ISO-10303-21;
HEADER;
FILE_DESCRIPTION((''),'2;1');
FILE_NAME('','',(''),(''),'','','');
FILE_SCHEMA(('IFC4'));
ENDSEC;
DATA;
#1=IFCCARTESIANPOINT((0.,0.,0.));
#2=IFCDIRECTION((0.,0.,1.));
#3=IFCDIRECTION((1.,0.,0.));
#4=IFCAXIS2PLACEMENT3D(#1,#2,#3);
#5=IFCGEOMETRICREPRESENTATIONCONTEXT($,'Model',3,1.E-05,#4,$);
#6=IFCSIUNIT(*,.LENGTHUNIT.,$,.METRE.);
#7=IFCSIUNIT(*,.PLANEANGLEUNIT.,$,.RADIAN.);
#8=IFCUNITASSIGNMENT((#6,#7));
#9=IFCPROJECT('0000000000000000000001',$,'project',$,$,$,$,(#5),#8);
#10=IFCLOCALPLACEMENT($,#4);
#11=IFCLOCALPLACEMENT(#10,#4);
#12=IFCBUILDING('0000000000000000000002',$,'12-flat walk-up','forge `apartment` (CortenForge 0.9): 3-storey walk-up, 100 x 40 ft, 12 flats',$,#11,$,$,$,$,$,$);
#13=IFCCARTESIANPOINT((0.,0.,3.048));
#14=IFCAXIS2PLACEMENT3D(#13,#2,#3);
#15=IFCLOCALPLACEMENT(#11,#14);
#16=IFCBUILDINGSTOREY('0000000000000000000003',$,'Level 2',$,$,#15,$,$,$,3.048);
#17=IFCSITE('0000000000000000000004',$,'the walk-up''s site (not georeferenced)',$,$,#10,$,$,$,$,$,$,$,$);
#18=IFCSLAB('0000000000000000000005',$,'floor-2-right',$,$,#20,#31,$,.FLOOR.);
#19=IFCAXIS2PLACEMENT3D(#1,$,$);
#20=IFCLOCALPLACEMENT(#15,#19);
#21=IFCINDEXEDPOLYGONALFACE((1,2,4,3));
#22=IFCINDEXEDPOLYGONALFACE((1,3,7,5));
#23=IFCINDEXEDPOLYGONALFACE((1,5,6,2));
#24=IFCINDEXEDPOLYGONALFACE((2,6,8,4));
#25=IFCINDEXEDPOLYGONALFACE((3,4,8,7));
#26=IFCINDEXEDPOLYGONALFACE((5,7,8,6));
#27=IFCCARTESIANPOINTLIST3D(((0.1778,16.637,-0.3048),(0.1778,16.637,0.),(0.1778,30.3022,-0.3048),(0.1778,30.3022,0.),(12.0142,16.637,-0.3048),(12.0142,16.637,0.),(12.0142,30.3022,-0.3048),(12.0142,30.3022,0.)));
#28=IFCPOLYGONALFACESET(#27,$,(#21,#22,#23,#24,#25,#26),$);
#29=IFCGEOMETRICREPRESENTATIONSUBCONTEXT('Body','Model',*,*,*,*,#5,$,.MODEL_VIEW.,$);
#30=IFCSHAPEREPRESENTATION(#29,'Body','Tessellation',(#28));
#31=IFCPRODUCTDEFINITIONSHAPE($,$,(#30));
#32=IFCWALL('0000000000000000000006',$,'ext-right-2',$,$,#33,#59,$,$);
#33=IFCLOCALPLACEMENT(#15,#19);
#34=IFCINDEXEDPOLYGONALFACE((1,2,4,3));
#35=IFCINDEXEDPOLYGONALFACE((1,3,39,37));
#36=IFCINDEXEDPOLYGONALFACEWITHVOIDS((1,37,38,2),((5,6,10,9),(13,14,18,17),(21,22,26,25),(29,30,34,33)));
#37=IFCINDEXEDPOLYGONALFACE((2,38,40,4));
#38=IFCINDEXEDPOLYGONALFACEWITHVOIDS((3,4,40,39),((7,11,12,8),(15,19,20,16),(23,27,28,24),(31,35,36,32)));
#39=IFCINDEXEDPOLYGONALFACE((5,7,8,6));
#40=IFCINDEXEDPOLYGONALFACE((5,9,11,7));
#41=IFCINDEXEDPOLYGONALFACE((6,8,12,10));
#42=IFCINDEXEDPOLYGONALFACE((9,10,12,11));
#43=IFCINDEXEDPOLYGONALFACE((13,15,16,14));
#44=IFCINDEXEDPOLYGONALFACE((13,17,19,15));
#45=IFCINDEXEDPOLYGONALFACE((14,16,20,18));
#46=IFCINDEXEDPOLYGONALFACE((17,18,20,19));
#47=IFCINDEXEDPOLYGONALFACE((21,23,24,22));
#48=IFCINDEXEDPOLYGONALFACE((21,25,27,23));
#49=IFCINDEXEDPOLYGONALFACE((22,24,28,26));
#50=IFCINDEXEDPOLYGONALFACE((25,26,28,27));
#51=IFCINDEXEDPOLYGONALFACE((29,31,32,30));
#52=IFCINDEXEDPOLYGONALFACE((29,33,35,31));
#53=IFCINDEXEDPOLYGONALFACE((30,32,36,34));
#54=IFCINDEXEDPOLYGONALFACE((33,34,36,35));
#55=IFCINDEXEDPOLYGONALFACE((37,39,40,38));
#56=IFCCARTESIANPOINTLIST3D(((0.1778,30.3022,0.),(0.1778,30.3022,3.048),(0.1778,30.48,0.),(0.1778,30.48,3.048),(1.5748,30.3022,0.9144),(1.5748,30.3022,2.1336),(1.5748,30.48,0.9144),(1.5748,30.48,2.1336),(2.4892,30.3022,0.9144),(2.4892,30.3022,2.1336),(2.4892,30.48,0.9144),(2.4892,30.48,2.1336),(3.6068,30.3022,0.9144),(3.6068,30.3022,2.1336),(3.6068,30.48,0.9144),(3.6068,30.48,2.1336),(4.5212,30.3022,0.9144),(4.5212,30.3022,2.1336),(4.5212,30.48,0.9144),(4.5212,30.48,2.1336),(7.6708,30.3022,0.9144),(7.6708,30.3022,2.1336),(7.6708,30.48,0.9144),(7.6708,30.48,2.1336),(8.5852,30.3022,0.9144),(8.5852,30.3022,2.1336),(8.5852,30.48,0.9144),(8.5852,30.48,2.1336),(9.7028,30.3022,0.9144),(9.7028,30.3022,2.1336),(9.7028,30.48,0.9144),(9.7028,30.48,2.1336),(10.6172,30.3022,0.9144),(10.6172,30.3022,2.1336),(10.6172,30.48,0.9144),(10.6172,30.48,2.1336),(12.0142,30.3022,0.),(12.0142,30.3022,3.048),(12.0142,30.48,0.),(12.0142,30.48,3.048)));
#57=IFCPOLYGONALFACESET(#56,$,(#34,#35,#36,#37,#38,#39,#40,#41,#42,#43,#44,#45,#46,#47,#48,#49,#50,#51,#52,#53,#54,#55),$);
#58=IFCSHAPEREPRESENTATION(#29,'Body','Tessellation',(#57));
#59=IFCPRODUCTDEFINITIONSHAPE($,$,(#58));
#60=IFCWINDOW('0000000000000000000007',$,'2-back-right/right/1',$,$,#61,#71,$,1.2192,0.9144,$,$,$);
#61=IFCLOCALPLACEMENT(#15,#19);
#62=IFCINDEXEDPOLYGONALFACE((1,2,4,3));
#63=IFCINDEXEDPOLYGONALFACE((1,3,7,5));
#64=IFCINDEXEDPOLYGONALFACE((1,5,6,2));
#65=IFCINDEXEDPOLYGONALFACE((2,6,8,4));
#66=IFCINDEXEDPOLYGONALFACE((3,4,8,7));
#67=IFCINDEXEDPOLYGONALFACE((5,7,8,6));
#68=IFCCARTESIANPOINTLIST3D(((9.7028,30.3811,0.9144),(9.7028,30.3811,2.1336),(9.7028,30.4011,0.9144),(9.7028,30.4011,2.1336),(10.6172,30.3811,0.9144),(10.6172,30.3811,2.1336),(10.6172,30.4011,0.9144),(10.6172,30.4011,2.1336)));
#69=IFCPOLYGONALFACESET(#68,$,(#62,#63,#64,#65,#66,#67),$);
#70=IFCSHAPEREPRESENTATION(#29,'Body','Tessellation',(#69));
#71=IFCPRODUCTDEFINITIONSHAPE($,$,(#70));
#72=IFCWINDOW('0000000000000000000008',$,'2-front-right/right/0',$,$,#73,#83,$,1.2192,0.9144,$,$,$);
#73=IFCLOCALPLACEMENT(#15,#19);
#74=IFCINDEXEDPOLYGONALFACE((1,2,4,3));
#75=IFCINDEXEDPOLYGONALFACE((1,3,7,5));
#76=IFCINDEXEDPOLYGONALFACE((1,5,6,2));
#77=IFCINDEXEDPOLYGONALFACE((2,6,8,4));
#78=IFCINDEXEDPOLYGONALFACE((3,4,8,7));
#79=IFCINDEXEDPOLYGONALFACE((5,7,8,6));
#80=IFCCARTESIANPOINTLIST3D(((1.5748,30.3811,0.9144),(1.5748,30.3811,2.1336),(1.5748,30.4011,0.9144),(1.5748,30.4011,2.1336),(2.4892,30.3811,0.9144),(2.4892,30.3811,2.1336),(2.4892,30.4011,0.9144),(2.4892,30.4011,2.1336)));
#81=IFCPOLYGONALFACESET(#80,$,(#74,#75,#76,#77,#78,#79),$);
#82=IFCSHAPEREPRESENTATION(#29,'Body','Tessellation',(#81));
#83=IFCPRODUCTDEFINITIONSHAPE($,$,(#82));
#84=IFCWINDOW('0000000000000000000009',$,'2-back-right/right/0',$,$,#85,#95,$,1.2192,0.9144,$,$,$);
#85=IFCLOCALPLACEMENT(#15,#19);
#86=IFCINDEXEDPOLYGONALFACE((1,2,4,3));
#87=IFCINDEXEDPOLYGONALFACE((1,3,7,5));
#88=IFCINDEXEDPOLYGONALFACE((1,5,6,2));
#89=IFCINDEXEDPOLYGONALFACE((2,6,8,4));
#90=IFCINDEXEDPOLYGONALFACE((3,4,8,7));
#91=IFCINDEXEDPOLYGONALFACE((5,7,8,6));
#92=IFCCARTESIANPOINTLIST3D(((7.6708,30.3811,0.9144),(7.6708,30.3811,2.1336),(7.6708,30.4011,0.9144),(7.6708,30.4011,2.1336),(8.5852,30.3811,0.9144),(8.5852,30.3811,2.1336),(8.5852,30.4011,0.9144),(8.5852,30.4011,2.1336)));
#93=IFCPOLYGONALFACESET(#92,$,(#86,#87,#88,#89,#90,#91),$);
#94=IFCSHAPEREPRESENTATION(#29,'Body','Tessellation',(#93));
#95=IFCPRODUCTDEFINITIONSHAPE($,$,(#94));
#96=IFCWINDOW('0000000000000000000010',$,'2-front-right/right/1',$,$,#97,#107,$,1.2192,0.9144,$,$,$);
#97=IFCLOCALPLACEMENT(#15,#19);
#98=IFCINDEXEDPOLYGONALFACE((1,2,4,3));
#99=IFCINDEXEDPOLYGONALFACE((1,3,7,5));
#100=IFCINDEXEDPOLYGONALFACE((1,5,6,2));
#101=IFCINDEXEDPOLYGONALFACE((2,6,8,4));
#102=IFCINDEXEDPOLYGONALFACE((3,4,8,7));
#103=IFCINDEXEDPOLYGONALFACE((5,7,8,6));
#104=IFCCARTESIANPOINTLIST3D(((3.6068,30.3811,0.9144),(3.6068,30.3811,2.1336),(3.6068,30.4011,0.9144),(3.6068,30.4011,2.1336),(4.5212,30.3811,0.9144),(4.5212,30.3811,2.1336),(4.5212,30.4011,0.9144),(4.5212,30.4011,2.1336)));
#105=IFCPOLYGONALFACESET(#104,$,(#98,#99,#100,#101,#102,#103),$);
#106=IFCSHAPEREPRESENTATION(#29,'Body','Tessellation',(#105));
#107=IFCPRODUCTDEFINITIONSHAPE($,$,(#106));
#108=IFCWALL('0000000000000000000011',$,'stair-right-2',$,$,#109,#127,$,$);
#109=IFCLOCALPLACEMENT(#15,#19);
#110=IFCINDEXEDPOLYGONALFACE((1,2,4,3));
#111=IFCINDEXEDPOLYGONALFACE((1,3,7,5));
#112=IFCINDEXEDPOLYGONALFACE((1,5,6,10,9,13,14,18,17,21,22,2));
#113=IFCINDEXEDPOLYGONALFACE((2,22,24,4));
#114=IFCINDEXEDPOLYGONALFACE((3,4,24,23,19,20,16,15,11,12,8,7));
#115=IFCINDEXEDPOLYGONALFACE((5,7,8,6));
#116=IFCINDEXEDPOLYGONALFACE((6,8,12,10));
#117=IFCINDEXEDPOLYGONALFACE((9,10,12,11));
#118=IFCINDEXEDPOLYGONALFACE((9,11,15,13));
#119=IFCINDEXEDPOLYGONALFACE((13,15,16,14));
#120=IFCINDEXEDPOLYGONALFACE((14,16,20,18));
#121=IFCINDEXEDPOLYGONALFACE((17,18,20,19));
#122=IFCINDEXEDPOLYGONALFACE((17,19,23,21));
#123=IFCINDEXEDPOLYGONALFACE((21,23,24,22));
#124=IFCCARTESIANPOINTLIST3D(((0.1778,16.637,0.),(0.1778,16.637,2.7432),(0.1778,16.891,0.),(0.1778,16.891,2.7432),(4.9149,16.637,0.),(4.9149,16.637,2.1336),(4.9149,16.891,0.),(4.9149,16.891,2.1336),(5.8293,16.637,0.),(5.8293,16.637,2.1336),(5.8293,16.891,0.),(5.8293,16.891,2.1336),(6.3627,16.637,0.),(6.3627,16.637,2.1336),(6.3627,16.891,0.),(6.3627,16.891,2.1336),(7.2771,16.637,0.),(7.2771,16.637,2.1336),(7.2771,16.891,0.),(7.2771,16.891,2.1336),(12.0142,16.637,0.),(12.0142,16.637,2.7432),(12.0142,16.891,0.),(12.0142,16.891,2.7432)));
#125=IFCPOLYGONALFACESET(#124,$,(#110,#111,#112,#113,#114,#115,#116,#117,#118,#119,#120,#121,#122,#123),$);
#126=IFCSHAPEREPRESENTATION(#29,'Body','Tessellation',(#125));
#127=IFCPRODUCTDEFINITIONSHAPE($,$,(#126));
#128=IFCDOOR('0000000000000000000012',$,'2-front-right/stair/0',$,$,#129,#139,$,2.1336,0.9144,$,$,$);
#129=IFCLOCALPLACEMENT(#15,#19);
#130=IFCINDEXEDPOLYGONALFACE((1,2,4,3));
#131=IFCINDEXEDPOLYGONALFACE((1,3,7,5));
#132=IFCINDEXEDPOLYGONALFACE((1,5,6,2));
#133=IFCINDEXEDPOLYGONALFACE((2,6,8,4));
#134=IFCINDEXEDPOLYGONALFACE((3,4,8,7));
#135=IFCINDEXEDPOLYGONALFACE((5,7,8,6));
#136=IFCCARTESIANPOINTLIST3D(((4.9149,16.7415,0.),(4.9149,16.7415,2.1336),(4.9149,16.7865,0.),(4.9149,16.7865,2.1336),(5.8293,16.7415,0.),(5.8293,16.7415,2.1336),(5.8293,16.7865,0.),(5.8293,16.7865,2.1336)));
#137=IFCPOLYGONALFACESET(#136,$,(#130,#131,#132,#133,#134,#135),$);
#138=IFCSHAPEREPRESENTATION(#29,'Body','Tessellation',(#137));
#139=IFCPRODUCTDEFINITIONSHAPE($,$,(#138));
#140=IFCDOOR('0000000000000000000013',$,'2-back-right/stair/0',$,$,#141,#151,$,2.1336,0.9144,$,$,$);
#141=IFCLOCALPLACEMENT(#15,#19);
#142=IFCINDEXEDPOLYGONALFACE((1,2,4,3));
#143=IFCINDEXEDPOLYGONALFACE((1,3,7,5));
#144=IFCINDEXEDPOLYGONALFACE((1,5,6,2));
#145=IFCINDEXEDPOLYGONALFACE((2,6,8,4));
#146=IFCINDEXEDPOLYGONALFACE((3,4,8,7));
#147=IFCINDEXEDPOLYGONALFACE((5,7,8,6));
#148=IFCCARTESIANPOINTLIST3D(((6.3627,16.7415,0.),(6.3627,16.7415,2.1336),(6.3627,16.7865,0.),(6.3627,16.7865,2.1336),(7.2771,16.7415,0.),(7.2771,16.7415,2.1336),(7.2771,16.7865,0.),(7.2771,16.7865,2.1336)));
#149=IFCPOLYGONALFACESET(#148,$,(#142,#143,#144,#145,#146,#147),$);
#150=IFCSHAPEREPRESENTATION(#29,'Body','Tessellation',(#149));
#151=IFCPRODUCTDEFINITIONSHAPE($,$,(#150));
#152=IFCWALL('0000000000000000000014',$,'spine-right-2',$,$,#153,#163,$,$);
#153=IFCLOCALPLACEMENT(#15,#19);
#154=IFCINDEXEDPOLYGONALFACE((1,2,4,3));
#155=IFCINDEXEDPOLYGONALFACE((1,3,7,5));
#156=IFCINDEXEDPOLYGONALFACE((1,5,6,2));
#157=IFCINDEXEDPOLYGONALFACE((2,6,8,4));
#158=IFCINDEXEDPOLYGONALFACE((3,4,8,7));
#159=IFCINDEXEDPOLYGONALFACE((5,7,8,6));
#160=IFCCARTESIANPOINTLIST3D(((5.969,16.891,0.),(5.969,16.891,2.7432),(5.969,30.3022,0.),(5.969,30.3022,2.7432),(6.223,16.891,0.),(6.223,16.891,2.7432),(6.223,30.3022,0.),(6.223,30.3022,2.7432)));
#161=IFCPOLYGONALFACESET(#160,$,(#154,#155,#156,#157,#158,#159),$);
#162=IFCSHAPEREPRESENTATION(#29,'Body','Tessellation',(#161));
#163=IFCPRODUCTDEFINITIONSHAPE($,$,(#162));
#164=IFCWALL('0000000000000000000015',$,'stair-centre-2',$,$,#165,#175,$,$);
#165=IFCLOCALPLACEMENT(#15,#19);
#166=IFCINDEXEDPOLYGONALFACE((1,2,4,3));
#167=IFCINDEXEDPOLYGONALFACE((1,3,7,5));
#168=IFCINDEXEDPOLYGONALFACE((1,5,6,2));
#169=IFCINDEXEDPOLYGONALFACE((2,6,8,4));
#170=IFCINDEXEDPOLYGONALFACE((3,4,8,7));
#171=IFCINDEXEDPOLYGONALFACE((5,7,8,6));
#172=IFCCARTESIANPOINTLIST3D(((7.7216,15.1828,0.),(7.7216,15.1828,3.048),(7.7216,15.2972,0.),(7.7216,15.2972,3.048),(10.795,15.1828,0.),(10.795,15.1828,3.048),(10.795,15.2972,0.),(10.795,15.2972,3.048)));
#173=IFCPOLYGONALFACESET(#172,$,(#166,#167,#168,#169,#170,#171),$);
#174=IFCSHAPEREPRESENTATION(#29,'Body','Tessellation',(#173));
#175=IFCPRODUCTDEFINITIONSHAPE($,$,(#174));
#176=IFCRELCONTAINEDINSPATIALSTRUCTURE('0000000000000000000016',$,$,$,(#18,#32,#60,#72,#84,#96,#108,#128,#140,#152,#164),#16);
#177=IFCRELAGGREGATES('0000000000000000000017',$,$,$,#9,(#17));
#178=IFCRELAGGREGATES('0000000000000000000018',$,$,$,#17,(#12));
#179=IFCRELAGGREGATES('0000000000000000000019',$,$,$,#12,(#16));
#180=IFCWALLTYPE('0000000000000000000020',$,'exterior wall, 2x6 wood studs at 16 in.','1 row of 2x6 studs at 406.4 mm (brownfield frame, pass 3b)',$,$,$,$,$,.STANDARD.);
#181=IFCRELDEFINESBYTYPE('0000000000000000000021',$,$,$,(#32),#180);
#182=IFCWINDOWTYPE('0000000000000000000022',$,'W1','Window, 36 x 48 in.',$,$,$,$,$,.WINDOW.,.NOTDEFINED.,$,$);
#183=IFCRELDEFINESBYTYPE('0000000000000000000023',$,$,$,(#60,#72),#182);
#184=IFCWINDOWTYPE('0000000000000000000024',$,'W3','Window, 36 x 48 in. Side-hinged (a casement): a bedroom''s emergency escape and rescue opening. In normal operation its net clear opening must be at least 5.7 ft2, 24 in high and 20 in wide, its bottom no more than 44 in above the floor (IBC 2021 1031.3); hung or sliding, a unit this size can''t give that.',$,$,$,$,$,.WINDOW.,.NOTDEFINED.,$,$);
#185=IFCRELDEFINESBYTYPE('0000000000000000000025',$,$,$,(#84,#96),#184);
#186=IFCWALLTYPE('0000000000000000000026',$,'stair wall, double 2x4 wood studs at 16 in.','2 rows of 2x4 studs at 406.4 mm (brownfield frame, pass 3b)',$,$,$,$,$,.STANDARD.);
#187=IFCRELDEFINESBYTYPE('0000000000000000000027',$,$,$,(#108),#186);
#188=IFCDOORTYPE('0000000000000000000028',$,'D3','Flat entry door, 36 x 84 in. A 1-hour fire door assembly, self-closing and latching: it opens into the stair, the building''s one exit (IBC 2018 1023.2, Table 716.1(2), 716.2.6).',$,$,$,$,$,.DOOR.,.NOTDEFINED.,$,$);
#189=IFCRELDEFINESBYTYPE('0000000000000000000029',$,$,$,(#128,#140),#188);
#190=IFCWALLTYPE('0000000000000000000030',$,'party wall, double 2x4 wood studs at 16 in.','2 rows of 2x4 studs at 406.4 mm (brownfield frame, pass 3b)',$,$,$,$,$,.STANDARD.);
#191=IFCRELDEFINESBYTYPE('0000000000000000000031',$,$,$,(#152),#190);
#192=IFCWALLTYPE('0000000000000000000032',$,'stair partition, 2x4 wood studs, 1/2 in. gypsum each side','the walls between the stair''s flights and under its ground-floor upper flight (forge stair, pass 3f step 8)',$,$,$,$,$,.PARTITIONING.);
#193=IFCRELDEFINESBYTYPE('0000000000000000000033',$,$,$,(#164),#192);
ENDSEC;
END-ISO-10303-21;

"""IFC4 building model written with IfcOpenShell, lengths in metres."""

from ifc_helpers import new_model, si_unit, frame, frame_2d, origin, origin_with_axes, place, context, subcontext, project, spatial, rectangle, extrude, type_object, element, fill, save


model = new_model("IFC4")

# Units and contexts
model_context = context("Model", 3, precision=1e-05, world=origin_with_axes())
body_context = subcontext(model_context, "Body", "Model", "MODEL_VIEW")
ifc_project = project(units=[si_unit("LENGTHUNIT", "METRE"), si_unit("PLANEANGLEUNIT", "RADIAN")], contexts=[model_context])

# Site, building, storey
site_placement = place(None, origin_with_axes())
site = spatial("IfcSite", under=ifc_project, at=site_placement, Name="the walk-up's site (not georeferenced)")
building_placement = place(site_placement, origin_with_axes())
building = spatial("IfcBuilding", under=site, at=building_placement, Name="12-flat walk-up", Description="forge `apartment` (CortenForge 0.9): 3-storey walk-up, 100 x 40 ft, 12 flats")
storey_placement = place(building_placement, frame((0.0, 0.0, 3.048), z_axis=(0.0, 0.0, 1.0), x_axis=(1.0, 0.0, 0.0)))
storey = spatial("IfcBuildingStorey", under=building, at=storey_placement, Name="Level 2", Elevation=3.048)

# Slab
slab_placement = place(storey_placement, frame((0.1778, 16.637, -0.3048), z_axis=(0.0, 0.0, 1.0), x_axis=(1.0, 0.0, 0.0)))
element("IfcSlab", 1, at=slab_placement, inside=storey, Name="floor-2-right", PredefinedType="FLOOR", context=body_context, shape_type="SweptSolid", body=[
    extrude(rectangle(XDim=11.8364, YDim=13.6652, at=frame_2d((5.9182, 6.8326))), origin(), (0.0, 0.0, 1.0), 0.3048),
])

# Wall, openings, windows
wall_type_1 = type_object("IfcWallType", Name="exterior wall, 2x6 wood studs at 16 in.", Description="1 row of 2x6 studs at 406.4 mm (brownfield frame, pass 3b)", PredefinedType="STANDARD")
wall_1_placement = place(storey_placement, frame((0.1778, 30.3022, 0.0), z_axis=(0.0, 0.0, 1.0), x_axis=(1.0, 0.0, 0.0)))
wall_1 = element("IfcWall", 2, at=wall_1_placement, inside=storey, type_object=wall_type_1, Name="ext-right-2", context=body_context, shape_type="SweptSolid", body=[
    extrude(rectangle(XDim=11.8364, YDim=0.1778, at=frame_2d((5.9182, 0.0889))), origin(), (0.0, 0.0, 1.0), 3.048),
])
opening_1_placement = place(wall_1_placement, frame((8.4074, 0.1778, 0.9144), z_axis=(0.0, 0.0, 1.0), x_axis=(-1.0, 0.0, 0.0)))
opening_1 = element("IfcOpeningElement", 3, at=opening_1_placement, cuts=wall_1, PredefinedType="OPENING", context=body_context, shape_type="SweptSolid", body=[
    extrude(rectangle(XDim=0.9144, YDim=0.1778, at=frame_2d((0.4572, 0.0889))), origin(), (0.0, 0.0, 1.0), 1.2192),
])
opening_2_placement = place(wall_1_placement, frame((10.4394, 0.1778, 0.9144), z_axis=(0.0, 0.0, 1.0), x_axis=(-1.0, 0.0, 0.0)))
opening_2 = element("IfcOpeningElement", 4, at=opening_2_placement, cuts=wall_1, PredefinedType="OPENING", context=body_context, shape_type="SweptSolid", body=[
    extrude(rectangle(XDim=0.9144, YDim=0.1778, at=frame_2d((0.4572, 0.0889))), origin(), (0.0, 0.0, 1.0), 1.2192),
])
opening_3_placement = place(wall_1_placement, frame((2.3114, 0.1778, 0.9144), z_axis=(0.0, 0.0, 1.0), x_axis=(-1.0, 0.0, 0.0)))
opening_3 = element("IfcOpeningElement", 5, at=opening_3_placement, cuts=wall_1, PredefinedType="OPENING", context=body_context, shape_type="SweptSolid", body=[
    extrude(rectangle(XDim=0.9144, YDim=0.1778, at=frame_2d((0.4572, 0.0889))), origin(), (0.0, 0.0, 1.0), 1.2192),
])
opening_4_placement = place(wall_1_placement, frame((4.3434, 0.1778, 0.9144), z_axis=(0.0, 0.0, 1.0), x_axis=(-1.0, 0.0, 0.0)))
opening_4 = element("IfcOpeningElement", 6, at=opening_4_placement, cuts=wall_1, PredefinedType="OPENING", context=body_context, shape_type="SweptSolid", body=[
    extrude(rectangle(XDim=0.9144, YDim=0.1778, at=frame_2d((0.4572, 0.0889))), origin(), (0.0, 0.0, 1.0), 1.2192),
])
window_type_1 = type_object("IfcWindowType", Name="W1", Description="Window, 36 x 48 in.", PartitioningType="NOTDEFINED", PredefinedType="WINDOW")
window_1_placement = place(opening_2_placement, frame((0.0, 0.0789, 0.0), z_axis=(0.0, 0.0, 1.0), x_axis=(1.0, 0.0, 0.0)))
window_1 = element("IfcWindow", 7, at=window_1_placement, inside=storey, type_object=window_type_1, Name="2-back-right/right/1", OverallHeight=1.2192, OverallWidth=0.9144, context=body_context, shape_type="SweptSolid", body=[
    extrude(rectangle(XDim=0.9144, YDim=0.02, at=frame_2d((0.4572, 0.01))), origin(), (0.0, 0.0, 1.0), 1.2192),
])
fill(opening_2, window_1)
window_2_placement = place(opening_3_placement, frame((0.0, 0.0789, 0.0), z_axis=(0.0, 0.0, 1.0), x_axis=(1.0, 0.0, 0.0)))
window_2 = element("IfcWindow", 8, at=window_2_placement, inside=storey, type_object=window_type_1, Name="2-front-right/right/0", OverallHeight=1.2192, OverallWidth=0.9144, context=body_context, shape_type="SweptSolid", body=[
    extrude(rectangle(XDim=0.9144, YDim=0.02, at=frame_2d((0.4572, 0.01))), origin(), (0.0, 0.0, 1.0), 1.2192),
])
fill(opening_3, window_2)
window_type_2 = type_object("IfcWindowType", Name="W3", Description="Window, 36 x 48 in. Side-hinged (a casement): a bedroom's emergency escape and rescue opening. In normal operation its net clear opening must be at least 5.7 ft2, 24 in high and 20 in wide, its bottom no more than 44 in above the floor (IBC 2021 1031.3); hung or sliding, a unit this size can't give that.", PartitioningType="NOTDEFINED", PredefinedType="WINDOW")
window_3_placement = place(opening_1_placement, frame((0.0, 0.0789, 0.0), z_axis=(0.0, 0.0, 1.0), x_axis=(1.0, 0.0, 0.0)))
window_3 = element("IfcWindow", 9, at=window_3_placement, inside=storey, type_object=window_type_2, Name="2-back-right/right/0", OverallHeight=1.2192, OverallWidth=0.9144, context=body_context, shape_type="SweptSolid", body=[
    extrude(rectangle(XDim=0.9144, YDim=0.02, at=frame_2d((0.4572, 0.01))), origin(), (0.0, 0.0, 1.0), 1.2192),
])
fill(opening_1, window_3)
window_4_placement = place(opening_4_placement, frame((0.0, 0.0789, 0.0), z_axis=(0.0, 0.0, 1.0), x_axis=(1.0, 0.0, 0.0)))
window_4 = element("IfcWindow", 10, at=window_4_placement, inside=storey, type_object=window_type_2, Name="2-front-right/right/1", OverallHeight=1.2192, OverallWidth=0.9144, context=body_context, shape_type="SweptSolid", body=[
    extrude(rectangle(XDim=0.9144, YDim=0.02, at=frame_2d((0.4572, 0.01))), origin(), (0.0, 0.0, 1.0), 1.2192),
])
fill(opening_4, window_4)

# Wall, openings, doors
wall_type_2 = type_object("IfcWallType", Name="stair wall, double 2x4 wood studs at 16 in.", Description="2 rows of 2x4 studs at 406.4 mm (brownfield frame, pass 3b)", PredefinedType="STANDARD")
wall_2_placement = place(storey_placement, frame((0.1778, 16.637, 0.0), z_axis=(0.0, 0.0, 1.0), x_axis=(1.0, 0.0, 0.0)))
wall_2 = element("IfcWall", 11, at=wall_2_placement, inside=storey, type_object=wall_type_2, Name="stair-right-2", context=body_context, shape_type="SweptSolid", body=[
    extrude(rectangle(XDim=11.8364, YDim=0.254, at=frame_2d((5.9182, 0.127))), origin(), (0.0, 0.0, 1.0), 2.7432),
])
opening_5_placement = place(wall_2_placement, frame((5.6515, 0.254, 0.0), z_axis=(0.0, 0.0, 1.0), x_axis=(-1.0, 0.0, 0.0)))
opening_5 = element("IfcOpeningElement", 12, at=opening_5_placement, cuts=wall_2, PredefinedType="OPENING", context=body_context, shape_type="SweptSolid", body=[
    extrude(rectangle(XDim=0.9144, YDim=0.254, at=frame_2d((0.4572, 0.127))), origin(), (0.0, 0.0, 1.0), 2.1336),
])
opening_6_placement = place(wall_2_placement, frame((7.0993, 0.254, 0.0), z_axis=(0.0, 0.0, 1.0), x_axis=(-1.0, 0.0, 0.0)))
opening_6 = element("IfcOpeningElement", 13, at=opening_6_placement, cuts=wall_2, PredefinedType="OPENING", context=body_context, shape_type="SweptSolid", body=[
    extrude(rectangle(XDim=0.9144, YDim=0.254, at=frame_2d((0.4572, 0.127))), origin(), (0.0, 0.0, 1.0), 2.1336),
])
door_type = type_object("IfcDoorType", Name="D3", Description="Flat entry door, 36 x 84 in. A 1-hour fire door assembly, self-closing and latching: it opens into the stair, the building's one exit (IBC 2018 1023.2, Table 716.1(2), 716.2.6).", OperationType="NOTDEFINED", PredefinedType="DOOR")
door_1_placement = place(opening_5_placement, frame((0.0, 0.1045, 0.0), z_axis=(0.0, 0.0, 1.0), x_axis=(1.0, 0.0, 0.0)))
door_1 = element("IfcDoor", 14, at=door_1_placement, inside=storey, type_object=door_type, Name="2-front-right/stair/0", OverallHeight=2.1336, OverallWidth=0.9144, context=body_context, shape_type="SweptSolid", body=[
    extrude(rectangle(XDim=0.9144, YDim=0.045, at=frame_2d((0.4572, 0.0225))), origin(), (0.0, 0.0, 1.0), 2.1336),
])
fill(opening_5, door_1)
door_2_placement = place(opening_6_placement, frame((0.0, 0.1045, 0.0), z_axis=(0.0, 0.0, 1.0), x_axis=(1.0, 0.0, 0.0)))
door_2 = element("IfcDoor", 15, at=door_2_placement, inside=storey, type_object=door_type, Name="2-back-right/stair/0", OverallHeight=2.1336, OverallWidth=0.9144, context=body_context, shape_type="SweptSolid", body=[
    extrude(rectangle(XDim=0.9144, YDim=0.045, at=frame_2d((0.4572, 0.0225))), origin(), (0.0, 0.0, 1.0), 2.1336),
])
fill(opening_6, door_2)

# Walls
wall_type_3 = type_object("IfcWallType", Name="party wall, double 2x4 wood studs at 16 in.", Description="2 rows of 2x4 studs at 406.4 mm (brownfield frame, pass 3b)", PredefinedType="STANDARD")
wall_3_placement = place(storey_placement, frame((5.969, 16.891, 0.0), z_axis=(0.0, 0.0, 1.0), x_axis=(1.0, 0.0, 0.0)))
element("IfcWall", 16, at=wall_3_placement, inside=storey, type_object=wall_type_3, Name="spine-right-2", context=body_context, shape_type="SweptSolid", body=[
    extrude(rectangle(XDim=0.254, YDim=13.4112, at=frame_2d((0.127, 6.7056))), origin(), (0.0, 0.0, 1.0), 2.7432),
])
wall_type_4 = type_object("IfcWallType", Name="stair partition, 2x4 wood studs, 1/2 in. gypsum each side", Description="the walls between the stair's flights and under its ground-floor upper flight (forge stair, pass 3f step 8)", PredefinedType="PARTITIONING")
wall_4_placement = place(storey_placement, frame((7.7216, 15.1829, 0.0), z_axis=(0.0, 0.0, 1.0), x_axis=(1.0, 0.0, 0.0)))
element("IfcWall", 17, at=wall_4_placement, inside=storey, type_object=wall_type_4, Name="stair-centre-2", context=body_context, shape_type="SweptSolid", body=[
    extrude(rectangle(XDim=3.0734, YDim=0.1143, at=frame_2d((1.5367, 0.0572))), origin(), (0.0, 0.0, 1.0), 3.048),
])

save(model, "model.ifc")
